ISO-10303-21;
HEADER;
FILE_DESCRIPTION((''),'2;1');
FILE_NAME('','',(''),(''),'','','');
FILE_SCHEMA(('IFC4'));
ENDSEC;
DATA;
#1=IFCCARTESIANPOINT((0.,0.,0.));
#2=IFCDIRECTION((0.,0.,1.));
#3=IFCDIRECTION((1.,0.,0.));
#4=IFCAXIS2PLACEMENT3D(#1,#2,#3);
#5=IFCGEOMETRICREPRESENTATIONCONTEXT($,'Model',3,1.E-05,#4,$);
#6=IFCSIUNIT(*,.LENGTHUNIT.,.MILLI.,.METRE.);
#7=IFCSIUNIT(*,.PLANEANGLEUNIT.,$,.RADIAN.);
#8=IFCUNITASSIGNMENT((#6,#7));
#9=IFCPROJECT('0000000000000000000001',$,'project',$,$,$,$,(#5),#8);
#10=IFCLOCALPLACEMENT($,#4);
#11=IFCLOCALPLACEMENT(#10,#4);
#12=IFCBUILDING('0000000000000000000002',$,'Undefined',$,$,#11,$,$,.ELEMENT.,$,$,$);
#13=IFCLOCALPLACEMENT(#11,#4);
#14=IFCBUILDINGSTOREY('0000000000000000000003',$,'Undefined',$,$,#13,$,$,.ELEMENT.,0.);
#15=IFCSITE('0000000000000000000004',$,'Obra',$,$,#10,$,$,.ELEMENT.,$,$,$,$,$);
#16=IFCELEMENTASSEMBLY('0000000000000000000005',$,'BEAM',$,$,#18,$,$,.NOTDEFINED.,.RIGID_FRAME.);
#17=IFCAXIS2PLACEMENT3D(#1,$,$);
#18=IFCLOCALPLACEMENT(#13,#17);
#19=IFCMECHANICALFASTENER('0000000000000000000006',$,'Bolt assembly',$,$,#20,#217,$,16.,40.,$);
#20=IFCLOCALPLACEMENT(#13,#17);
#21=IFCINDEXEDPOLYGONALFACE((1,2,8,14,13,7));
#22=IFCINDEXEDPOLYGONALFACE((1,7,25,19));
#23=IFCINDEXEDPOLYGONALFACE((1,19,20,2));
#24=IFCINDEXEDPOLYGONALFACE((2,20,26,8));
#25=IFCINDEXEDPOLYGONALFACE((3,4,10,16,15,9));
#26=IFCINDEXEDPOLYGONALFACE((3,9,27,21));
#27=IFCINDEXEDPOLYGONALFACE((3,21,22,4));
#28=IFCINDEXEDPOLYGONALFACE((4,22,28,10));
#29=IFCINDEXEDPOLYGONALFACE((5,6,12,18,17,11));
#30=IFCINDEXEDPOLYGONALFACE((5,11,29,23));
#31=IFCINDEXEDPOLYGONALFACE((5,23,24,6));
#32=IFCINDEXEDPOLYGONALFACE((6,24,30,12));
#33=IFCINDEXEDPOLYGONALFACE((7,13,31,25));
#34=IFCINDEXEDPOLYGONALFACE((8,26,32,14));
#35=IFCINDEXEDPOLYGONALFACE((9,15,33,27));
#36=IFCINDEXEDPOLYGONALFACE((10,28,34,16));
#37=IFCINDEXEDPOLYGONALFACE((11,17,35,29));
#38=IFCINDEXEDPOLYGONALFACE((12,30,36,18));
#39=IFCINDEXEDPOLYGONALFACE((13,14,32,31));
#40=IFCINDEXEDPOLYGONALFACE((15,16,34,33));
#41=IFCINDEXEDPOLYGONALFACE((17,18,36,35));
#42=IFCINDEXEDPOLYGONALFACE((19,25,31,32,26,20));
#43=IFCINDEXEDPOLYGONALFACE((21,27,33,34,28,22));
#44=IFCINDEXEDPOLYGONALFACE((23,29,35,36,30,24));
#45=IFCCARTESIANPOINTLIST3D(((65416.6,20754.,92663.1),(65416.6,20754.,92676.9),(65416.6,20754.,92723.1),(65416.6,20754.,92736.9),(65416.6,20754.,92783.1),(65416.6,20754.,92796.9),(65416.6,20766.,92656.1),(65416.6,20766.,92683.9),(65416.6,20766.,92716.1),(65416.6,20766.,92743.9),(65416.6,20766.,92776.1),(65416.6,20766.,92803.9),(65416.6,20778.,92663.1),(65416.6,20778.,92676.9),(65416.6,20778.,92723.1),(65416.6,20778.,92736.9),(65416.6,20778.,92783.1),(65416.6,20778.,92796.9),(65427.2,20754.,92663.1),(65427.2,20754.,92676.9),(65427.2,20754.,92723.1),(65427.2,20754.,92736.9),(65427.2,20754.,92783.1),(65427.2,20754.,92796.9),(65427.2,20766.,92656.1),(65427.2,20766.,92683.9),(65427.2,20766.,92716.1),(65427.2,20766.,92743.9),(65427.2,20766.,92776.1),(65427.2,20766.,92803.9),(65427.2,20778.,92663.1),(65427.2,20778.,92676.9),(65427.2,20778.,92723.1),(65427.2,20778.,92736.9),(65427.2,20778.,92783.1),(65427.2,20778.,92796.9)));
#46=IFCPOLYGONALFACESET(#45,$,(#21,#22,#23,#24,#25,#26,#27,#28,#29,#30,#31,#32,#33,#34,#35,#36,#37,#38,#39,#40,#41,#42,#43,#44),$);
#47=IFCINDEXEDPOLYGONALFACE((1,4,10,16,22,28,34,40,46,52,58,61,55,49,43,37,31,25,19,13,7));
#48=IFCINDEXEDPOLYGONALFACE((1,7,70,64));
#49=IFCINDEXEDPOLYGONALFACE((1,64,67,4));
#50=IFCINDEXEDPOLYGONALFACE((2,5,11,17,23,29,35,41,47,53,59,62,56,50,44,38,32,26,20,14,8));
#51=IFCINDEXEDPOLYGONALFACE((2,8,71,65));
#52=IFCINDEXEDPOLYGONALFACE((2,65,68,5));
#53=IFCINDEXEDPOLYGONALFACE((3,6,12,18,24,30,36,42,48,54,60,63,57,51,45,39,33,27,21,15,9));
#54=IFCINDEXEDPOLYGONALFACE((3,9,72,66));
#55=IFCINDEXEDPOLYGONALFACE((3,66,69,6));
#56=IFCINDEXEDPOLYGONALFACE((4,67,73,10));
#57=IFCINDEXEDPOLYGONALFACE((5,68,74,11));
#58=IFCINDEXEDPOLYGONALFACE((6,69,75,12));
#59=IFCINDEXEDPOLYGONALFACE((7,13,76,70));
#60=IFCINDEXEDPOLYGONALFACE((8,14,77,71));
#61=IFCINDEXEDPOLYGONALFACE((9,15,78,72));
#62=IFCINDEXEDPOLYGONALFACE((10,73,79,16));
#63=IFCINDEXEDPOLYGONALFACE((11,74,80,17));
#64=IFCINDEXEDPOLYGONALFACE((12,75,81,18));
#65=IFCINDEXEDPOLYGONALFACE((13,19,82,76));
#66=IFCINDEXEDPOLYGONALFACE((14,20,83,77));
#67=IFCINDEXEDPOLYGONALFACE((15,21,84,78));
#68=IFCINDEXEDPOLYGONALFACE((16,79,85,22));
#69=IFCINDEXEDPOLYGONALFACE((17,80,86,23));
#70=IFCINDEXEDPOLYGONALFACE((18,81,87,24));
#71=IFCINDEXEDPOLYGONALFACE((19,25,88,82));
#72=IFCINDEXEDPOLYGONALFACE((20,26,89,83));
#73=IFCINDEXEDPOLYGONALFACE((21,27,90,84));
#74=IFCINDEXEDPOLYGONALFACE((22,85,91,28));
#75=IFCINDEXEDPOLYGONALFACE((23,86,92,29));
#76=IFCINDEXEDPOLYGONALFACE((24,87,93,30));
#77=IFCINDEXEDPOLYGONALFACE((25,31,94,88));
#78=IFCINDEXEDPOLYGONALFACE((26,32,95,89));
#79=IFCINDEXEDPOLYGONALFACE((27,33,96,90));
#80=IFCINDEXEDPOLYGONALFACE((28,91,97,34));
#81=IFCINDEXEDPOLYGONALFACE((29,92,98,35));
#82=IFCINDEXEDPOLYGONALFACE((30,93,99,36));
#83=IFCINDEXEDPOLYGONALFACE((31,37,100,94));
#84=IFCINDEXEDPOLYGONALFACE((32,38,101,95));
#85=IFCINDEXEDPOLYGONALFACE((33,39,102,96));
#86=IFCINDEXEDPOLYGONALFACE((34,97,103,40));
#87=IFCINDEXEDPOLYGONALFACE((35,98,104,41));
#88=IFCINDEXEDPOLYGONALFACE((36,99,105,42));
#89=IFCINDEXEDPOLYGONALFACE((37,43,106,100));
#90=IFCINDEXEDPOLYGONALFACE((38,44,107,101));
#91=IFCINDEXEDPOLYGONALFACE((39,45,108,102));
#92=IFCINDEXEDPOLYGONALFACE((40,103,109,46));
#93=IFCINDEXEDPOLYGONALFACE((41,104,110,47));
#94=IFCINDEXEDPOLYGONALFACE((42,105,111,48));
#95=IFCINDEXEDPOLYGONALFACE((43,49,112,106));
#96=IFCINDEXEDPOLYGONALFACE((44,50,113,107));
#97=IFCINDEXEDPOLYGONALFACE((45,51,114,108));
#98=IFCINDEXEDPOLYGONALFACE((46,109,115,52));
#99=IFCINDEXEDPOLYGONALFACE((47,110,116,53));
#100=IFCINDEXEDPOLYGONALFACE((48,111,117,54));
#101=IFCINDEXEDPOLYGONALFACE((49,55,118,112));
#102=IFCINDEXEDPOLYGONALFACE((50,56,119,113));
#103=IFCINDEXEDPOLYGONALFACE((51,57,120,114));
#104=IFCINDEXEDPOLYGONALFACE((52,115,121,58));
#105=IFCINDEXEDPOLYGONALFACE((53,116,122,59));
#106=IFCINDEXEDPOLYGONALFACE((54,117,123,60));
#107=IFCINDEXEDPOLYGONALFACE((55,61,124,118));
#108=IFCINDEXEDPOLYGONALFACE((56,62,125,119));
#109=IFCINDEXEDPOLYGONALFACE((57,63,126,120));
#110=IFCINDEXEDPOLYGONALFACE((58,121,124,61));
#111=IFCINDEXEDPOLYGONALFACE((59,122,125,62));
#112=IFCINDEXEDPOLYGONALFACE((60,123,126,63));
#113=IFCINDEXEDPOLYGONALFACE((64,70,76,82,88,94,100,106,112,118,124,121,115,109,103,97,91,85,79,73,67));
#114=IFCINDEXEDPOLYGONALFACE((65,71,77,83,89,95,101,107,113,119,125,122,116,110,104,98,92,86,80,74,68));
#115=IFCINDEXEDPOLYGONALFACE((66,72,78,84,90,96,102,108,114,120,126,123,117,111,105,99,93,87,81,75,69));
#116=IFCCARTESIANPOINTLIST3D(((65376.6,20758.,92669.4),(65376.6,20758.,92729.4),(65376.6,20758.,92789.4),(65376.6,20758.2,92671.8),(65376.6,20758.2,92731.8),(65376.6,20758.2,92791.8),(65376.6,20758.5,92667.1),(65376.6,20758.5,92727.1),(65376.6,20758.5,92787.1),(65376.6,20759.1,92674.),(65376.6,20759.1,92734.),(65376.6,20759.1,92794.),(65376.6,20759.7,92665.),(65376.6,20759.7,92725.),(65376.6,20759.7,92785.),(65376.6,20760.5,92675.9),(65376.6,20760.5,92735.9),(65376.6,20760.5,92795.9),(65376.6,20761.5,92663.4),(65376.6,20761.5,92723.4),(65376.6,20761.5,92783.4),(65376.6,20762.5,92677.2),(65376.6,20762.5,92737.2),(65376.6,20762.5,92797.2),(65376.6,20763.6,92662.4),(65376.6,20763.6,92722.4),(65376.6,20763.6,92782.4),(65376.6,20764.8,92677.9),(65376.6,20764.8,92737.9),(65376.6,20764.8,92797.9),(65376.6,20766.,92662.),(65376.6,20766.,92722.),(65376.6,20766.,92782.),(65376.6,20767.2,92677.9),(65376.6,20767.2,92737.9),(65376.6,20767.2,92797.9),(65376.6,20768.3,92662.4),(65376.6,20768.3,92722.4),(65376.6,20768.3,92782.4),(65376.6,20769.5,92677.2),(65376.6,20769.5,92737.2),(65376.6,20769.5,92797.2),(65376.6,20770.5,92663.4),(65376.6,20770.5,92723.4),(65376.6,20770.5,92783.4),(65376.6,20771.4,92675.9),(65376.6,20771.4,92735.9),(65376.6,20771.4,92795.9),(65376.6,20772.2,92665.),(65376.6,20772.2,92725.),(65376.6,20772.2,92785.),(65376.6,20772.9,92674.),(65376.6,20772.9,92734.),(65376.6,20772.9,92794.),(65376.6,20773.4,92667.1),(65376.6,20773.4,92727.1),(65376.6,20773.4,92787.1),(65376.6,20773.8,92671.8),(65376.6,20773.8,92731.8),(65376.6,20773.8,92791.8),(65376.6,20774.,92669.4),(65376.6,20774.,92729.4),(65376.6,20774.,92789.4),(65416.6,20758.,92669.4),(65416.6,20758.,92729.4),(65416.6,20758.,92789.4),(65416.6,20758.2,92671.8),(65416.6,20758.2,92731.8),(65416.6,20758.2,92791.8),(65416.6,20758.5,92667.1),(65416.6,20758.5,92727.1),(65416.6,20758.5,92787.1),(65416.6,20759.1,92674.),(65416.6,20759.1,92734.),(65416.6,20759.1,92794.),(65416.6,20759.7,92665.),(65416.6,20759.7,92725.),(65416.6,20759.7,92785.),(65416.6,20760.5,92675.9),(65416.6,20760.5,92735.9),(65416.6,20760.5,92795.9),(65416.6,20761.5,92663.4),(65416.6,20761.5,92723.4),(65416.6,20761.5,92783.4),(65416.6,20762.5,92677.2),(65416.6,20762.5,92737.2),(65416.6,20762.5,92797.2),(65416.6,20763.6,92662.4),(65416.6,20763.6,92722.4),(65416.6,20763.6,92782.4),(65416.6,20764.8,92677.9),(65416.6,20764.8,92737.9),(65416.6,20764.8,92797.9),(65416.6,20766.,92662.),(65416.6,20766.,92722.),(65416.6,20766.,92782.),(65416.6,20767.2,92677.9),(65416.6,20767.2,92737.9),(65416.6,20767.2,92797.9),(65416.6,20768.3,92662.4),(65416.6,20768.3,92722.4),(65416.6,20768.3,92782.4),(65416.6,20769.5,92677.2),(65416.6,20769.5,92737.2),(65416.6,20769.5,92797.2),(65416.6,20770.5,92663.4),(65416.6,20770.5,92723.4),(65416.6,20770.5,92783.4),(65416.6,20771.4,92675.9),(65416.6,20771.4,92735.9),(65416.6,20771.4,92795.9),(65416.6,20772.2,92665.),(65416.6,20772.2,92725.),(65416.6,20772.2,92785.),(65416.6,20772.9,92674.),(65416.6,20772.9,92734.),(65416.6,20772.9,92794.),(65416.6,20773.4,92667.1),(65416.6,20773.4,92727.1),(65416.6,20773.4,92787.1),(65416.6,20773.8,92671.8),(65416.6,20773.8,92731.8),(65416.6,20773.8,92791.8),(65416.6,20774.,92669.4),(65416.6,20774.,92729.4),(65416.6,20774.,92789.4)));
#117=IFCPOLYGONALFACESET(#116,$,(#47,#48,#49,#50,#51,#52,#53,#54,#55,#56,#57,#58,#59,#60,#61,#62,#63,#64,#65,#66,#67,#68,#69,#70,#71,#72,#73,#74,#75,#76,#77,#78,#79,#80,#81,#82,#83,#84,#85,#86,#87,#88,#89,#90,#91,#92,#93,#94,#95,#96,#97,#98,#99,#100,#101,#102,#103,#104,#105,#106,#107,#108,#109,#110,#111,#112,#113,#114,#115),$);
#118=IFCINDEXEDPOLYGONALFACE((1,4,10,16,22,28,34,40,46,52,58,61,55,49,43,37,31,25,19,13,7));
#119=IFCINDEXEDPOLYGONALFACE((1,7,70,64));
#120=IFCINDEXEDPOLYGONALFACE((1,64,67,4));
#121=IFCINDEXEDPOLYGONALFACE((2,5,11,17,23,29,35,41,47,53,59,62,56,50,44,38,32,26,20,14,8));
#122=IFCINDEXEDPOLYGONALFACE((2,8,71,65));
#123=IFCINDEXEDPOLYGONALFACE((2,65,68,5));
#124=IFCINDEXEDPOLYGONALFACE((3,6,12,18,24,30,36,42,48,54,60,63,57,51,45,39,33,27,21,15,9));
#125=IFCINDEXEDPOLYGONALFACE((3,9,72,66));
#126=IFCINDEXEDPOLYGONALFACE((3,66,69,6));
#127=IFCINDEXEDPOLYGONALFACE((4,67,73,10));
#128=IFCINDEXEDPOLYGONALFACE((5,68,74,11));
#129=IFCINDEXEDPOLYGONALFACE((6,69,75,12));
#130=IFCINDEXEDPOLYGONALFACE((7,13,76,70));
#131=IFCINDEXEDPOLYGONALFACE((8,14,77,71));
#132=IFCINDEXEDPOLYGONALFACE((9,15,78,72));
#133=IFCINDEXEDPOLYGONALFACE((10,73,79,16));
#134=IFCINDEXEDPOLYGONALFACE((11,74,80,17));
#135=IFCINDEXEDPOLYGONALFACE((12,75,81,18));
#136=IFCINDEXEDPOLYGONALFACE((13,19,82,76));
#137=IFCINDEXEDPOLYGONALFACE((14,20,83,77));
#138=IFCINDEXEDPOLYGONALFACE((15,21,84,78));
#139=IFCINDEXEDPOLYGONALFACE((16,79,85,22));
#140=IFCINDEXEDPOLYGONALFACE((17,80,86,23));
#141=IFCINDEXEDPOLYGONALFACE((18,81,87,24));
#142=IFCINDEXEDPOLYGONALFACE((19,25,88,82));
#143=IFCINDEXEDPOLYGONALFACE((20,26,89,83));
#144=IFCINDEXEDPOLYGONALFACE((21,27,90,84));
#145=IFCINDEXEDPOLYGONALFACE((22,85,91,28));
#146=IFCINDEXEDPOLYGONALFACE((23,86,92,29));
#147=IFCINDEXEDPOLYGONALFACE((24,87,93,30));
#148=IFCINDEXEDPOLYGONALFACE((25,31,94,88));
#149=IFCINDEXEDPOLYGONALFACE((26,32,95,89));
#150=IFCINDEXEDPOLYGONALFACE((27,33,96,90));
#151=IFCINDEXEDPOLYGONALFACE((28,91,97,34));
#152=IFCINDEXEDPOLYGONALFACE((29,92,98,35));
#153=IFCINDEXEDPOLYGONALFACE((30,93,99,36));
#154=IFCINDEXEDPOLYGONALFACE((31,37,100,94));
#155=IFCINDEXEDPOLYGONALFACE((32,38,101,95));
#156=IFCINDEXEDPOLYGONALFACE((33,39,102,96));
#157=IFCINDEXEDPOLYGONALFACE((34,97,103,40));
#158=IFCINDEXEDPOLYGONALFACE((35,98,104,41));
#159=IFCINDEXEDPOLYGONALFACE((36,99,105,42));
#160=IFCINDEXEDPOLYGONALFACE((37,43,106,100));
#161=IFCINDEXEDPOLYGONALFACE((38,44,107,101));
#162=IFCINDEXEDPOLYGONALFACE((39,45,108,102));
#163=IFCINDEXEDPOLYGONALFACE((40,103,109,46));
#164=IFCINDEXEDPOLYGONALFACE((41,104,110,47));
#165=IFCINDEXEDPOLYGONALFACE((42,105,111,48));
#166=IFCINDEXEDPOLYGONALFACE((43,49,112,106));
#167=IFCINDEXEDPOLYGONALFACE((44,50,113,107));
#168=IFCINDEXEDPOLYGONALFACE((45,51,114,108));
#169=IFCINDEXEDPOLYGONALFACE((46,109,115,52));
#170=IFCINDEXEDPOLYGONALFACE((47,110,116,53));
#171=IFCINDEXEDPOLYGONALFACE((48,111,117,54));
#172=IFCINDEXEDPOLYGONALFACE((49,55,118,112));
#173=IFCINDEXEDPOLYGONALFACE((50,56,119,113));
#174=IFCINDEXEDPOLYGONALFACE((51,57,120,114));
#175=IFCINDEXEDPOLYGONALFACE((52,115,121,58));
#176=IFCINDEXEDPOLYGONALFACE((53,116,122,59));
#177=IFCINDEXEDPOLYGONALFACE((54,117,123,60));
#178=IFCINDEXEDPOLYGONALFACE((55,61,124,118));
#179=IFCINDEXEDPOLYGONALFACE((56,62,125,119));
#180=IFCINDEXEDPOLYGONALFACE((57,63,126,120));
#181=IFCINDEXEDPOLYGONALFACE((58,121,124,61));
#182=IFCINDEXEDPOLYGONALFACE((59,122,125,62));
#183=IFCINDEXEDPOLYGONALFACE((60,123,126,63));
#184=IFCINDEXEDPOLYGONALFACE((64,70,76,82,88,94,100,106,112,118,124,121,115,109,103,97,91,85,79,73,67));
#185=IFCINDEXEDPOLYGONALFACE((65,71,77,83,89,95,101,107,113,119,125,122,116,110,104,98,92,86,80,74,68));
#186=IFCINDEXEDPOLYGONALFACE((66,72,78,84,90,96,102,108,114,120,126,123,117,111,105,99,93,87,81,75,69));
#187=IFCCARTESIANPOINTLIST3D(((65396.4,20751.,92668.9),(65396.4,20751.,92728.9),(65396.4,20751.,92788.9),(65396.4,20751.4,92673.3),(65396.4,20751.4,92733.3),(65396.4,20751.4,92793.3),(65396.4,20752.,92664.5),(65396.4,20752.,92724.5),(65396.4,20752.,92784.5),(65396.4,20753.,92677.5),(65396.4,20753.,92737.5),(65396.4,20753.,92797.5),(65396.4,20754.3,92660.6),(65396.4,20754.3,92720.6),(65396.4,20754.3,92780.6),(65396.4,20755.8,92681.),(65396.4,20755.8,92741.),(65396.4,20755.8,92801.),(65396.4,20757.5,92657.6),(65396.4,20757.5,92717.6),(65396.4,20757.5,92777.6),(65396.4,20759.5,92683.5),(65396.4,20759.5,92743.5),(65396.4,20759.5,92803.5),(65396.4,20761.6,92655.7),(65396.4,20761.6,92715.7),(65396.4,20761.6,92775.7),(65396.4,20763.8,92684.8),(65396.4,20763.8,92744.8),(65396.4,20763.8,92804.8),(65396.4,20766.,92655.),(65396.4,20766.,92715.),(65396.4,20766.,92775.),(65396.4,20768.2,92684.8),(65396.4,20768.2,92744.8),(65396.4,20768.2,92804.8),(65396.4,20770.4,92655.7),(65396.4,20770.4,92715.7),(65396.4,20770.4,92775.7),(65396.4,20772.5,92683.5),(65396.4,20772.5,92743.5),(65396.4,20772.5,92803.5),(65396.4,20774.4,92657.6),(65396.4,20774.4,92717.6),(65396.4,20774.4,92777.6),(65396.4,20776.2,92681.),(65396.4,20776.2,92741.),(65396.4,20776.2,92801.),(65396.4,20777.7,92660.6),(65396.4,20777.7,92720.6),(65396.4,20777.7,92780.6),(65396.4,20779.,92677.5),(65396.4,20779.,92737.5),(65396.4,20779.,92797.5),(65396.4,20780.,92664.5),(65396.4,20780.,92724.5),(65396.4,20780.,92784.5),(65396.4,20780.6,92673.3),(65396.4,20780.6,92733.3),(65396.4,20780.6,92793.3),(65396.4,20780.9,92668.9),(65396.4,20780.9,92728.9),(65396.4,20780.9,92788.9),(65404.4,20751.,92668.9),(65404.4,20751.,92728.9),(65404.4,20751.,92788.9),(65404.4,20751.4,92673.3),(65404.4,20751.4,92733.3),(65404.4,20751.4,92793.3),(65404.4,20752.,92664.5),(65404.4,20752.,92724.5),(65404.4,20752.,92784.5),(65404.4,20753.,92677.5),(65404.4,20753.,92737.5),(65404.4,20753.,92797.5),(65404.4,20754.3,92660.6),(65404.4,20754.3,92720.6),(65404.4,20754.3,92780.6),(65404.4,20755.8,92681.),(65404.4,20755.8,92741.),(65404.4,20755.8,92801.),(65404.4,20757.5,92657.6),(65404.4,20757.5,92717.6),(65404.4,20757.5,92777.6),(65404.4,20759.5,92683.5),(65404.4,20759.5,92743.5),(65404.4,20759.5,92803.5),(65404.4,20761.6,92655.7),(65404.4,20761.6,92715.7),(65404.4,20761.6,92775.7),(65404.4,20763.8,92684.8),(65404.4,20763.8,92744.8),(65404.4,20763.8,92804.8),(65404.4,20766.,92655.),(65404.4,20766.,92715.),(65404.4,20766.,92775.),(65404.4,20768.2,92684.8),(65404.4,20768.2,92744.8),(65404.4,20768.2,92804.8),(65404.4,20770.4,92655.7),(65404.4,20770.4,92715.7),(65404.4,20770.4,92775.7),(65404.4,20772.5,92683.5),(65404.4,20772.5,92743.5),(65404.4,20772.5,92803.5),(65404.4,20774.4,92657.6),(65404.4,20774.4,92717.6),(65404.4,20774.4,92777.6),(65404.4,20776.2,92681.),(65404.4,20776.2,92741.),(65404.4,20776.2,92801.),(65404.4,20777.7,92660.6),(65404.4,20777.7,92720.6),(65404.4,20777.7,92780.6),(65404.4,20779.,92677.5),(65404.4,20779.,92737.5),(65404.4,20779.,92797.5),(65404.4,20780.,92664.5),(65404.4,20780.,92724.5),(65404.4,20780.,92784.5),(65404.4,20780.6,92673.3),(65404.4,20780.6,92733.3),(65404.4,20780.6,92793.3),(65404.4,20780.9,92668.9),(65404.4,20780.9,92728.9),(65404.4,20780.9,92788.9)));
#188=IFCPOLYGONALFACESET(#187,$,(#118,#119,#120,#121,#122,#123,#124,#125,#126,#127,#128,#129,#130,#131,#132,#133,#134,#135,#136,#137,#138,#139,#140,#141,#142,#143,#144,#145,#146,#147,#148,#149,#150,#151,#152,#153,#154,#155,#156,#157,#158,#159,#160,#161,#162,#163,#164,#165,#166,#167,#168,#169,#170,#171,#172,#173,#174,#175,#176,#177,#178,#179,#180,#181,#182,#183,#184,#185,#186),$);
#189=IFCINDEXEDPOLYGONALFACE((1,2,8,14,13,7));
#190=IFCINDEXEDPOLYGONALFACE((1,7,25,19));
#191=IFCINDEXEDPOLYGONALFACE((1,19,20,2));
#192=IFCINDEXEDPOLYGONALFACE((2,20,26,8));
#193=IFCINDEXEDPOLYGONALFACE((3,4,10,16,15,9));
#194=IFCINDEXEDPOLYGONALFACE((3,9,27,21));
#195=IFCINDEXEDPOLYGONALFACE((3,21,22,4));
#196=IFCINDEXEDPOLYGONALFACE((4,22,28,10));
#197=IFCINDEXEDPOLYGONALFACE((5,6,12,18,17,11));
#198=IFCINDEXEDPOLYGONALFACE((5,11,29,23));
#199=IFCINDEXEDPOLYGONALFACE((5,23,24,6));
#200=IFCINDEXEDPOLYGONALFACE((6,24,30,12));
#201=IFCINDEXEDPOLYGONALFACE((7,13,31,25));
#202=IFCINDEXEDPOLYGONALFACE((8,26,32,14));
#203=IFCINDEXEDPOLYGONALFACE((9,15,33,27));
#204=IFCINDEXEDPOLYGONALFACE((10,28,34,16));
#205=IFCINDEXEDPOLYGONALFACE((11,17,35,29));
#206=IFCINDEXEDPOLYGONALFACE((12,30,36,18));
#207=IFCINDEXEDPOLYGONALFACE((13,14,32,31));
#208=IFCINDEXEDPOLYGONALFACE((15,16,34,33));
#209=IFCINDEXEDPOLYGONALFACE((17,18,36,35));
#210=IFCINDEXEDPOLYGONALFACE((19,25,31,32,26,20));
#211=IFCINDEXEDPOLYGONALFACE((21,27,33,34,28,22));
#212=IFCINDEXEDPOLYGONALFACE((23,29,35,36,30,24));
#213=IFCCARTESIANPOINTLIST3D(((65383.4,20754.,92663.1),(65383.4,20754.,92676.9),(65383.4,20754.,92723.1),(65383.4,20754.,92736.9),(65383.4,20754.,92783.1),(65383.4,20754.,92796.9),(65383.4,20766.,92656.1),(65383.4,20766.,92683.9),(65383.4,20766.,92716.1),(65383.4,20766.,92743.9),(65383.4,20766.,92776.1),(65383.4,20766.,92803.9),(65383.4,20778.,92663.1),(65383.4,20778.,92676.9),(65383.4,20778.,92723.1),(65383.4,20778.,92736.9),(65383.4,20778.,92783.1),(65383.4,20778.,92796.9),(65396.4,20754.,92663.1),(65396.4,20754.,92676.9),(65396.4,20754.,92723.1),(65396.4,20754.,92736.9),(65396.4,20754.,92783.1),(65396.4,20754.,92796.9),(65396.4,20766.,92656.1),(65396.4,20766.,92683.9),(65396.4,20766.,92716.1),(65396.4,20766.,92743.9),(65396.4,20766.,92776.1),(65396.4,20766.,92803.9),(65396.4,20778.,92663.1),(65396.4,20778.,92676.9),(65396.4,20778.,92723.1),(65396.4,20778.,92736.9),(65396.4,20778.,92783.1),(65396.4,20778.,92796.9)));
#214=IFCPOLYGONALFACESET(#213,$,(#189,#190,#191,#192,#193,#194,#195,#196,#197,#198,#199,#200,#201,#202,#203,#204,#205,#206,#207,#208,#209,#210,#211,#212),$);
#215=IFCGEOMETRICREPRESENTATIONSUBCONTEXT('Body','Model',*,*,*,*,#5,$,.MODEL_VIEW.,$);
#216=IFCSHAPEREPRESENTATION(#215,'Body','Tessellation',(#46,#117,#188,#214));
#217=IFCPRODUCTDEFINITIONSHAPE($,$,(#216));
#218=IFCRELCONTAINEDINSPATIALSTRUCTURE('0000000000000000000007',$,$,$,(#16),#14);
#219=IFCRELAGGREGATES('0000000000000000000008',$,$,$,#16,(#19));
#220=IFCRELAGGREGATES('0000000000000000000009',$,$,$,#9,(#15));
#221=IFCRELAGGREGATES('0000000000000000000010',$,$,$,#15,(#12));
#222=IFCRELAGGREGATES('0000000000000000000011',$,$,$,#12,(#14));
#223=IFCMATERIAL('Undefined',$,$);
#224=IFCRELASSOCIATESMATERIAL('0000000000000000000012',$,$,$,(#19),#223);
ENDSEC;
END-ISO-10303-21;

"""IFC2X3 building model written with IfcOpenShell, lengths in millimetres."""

from ifc_helpers import new_model, si_unit, frame, origin_with_axes, origin_2d_with_axis, place, context, subcontext, project, spatial, polyline, circle, outline, extrude, source, transform, mapped, material, element, aggregate, save


model = new_model("IFC2X3")

# Units and contexts
model_context = context("Model", 3, precision=1e-05, world=origin_with_axes())
body_context = subcontext(model_context, "Body", "Model", "MODEL_VIEW")
ifc_project = project(units=[si_unit("LENGTHUNIT", "METRE", prefix="MILLI"), si_unit("PLANEANGLEUNIT", "RADIAN")], contexts=[model_context])

# Site, building, storey
site_placement = place(None, origin_with_axes())
site = spatial("IfcSite", under=ifc_project, at=site_placement, Name="Obra", CompositionType="ELEMENT")
building_placement = place(site_placement, origin_with_axes())
building = spatial("IfcBuilding", under=site, at=building_placement, Name="Undefined", CompositionType="ELEMENT")
storey_placement = place(building_placement, origin_with_axes())
storey = spatial("IfcBuildingStorey", under=building, at=storey_placement, Name="Undefined", CompositionType="ELEMENT", Elevation=0.0)

# Shared definitions
ifc_material_1 = material(Name="Undefined")

# Element assembly, mechanical fastener
shared_shape_1 = source(origin_with_axes(), body_context, "Body", "SweptSolid", [
    extrude(outline(polyline([(13.9, 0.0), (6.9, 12.0), (-6.9, 12.0), (-13.9, 0.0), (-6.9, -12.0), (6.9, -12.0), (13.9, 0.0)])), frame((0.0, -19.7, 0.0), z_axis=(0.0, 1.0, 0.0), x_axis=(1.0, 0.0, 0.0)), (0.0, 0.0, 1.0), 10.6),
    extrude(circle(Radius=8.0, at=origin_2d_with_axis()), frame((0.0, -9.1, 0.0), z_axis=(0.0, 1.0, 0.0), x_axis=(1.0, 0.0, 0.0)), (0.0, 0.0, 1.0), 40.0),
    extrude(circle(Radius=15.0, at=origin_2d_with_axis()), frame((0.0, 3.1, 0.0), z_axis=(0.0, 1.0, 0.0), x_axis=(1.0, 0.0, 0.0)), (0.0, 0.0, 1.0), 8.0),
    extrude(outline(polyline([(13.9, 0.0), (6.9, 12.0), (-6.9, 12.0), (-13.9, 0.0), (-6.9, -12.0), (6.9, -12.0), (13.9, 0.0)])), frame((0.0, 11.1, 0.0), z_axis=(0.0, 1.0, 0.0), x_axis=(1.0, 0.0, 0.0)), (0.0, 0.0, 1.0), 13.0),
])
assembly_1_placement = place(storey_placement, origin_with_axes())
assembly_1 = element("IfcElementAssembly", 1, at=assembly_1_placement, inside=storey, Name="BEAM", AssemblyPlace="NOTDEFINED", PredefinedType="RIGID_FRAME")
mechanical_fastener_1_placement = place(assembly_1_placement, frame((65407.5, 20716.0, 92850.0), z_axis=(-0.000002, 1.0, 0.0), x_axis=(0.0, 0.0, -1.0)))
mechanical_fastener_1 = element("IfcMechanicalFastener", 2, at=mechanical_fastener_1_placement, material=ifc_material_1, Name="Bolt assembly", NominalDiameter=16.0, NominalLength=40.0, context=body_context, shape_type="MappedRepresentation", body=[
    mapped(shared_shape_1, transform((60.0, 0.0, 50.0))),
    mapped(shared_shape_1, transform((120.0, 0.0, 50.0))),
    mapped(shared_shape_1, transform((180.0, 0.0, 50.0))),
])

aggregate(assembly_1, [mechanical_fastener_1])

save(model, "model.ifc")
